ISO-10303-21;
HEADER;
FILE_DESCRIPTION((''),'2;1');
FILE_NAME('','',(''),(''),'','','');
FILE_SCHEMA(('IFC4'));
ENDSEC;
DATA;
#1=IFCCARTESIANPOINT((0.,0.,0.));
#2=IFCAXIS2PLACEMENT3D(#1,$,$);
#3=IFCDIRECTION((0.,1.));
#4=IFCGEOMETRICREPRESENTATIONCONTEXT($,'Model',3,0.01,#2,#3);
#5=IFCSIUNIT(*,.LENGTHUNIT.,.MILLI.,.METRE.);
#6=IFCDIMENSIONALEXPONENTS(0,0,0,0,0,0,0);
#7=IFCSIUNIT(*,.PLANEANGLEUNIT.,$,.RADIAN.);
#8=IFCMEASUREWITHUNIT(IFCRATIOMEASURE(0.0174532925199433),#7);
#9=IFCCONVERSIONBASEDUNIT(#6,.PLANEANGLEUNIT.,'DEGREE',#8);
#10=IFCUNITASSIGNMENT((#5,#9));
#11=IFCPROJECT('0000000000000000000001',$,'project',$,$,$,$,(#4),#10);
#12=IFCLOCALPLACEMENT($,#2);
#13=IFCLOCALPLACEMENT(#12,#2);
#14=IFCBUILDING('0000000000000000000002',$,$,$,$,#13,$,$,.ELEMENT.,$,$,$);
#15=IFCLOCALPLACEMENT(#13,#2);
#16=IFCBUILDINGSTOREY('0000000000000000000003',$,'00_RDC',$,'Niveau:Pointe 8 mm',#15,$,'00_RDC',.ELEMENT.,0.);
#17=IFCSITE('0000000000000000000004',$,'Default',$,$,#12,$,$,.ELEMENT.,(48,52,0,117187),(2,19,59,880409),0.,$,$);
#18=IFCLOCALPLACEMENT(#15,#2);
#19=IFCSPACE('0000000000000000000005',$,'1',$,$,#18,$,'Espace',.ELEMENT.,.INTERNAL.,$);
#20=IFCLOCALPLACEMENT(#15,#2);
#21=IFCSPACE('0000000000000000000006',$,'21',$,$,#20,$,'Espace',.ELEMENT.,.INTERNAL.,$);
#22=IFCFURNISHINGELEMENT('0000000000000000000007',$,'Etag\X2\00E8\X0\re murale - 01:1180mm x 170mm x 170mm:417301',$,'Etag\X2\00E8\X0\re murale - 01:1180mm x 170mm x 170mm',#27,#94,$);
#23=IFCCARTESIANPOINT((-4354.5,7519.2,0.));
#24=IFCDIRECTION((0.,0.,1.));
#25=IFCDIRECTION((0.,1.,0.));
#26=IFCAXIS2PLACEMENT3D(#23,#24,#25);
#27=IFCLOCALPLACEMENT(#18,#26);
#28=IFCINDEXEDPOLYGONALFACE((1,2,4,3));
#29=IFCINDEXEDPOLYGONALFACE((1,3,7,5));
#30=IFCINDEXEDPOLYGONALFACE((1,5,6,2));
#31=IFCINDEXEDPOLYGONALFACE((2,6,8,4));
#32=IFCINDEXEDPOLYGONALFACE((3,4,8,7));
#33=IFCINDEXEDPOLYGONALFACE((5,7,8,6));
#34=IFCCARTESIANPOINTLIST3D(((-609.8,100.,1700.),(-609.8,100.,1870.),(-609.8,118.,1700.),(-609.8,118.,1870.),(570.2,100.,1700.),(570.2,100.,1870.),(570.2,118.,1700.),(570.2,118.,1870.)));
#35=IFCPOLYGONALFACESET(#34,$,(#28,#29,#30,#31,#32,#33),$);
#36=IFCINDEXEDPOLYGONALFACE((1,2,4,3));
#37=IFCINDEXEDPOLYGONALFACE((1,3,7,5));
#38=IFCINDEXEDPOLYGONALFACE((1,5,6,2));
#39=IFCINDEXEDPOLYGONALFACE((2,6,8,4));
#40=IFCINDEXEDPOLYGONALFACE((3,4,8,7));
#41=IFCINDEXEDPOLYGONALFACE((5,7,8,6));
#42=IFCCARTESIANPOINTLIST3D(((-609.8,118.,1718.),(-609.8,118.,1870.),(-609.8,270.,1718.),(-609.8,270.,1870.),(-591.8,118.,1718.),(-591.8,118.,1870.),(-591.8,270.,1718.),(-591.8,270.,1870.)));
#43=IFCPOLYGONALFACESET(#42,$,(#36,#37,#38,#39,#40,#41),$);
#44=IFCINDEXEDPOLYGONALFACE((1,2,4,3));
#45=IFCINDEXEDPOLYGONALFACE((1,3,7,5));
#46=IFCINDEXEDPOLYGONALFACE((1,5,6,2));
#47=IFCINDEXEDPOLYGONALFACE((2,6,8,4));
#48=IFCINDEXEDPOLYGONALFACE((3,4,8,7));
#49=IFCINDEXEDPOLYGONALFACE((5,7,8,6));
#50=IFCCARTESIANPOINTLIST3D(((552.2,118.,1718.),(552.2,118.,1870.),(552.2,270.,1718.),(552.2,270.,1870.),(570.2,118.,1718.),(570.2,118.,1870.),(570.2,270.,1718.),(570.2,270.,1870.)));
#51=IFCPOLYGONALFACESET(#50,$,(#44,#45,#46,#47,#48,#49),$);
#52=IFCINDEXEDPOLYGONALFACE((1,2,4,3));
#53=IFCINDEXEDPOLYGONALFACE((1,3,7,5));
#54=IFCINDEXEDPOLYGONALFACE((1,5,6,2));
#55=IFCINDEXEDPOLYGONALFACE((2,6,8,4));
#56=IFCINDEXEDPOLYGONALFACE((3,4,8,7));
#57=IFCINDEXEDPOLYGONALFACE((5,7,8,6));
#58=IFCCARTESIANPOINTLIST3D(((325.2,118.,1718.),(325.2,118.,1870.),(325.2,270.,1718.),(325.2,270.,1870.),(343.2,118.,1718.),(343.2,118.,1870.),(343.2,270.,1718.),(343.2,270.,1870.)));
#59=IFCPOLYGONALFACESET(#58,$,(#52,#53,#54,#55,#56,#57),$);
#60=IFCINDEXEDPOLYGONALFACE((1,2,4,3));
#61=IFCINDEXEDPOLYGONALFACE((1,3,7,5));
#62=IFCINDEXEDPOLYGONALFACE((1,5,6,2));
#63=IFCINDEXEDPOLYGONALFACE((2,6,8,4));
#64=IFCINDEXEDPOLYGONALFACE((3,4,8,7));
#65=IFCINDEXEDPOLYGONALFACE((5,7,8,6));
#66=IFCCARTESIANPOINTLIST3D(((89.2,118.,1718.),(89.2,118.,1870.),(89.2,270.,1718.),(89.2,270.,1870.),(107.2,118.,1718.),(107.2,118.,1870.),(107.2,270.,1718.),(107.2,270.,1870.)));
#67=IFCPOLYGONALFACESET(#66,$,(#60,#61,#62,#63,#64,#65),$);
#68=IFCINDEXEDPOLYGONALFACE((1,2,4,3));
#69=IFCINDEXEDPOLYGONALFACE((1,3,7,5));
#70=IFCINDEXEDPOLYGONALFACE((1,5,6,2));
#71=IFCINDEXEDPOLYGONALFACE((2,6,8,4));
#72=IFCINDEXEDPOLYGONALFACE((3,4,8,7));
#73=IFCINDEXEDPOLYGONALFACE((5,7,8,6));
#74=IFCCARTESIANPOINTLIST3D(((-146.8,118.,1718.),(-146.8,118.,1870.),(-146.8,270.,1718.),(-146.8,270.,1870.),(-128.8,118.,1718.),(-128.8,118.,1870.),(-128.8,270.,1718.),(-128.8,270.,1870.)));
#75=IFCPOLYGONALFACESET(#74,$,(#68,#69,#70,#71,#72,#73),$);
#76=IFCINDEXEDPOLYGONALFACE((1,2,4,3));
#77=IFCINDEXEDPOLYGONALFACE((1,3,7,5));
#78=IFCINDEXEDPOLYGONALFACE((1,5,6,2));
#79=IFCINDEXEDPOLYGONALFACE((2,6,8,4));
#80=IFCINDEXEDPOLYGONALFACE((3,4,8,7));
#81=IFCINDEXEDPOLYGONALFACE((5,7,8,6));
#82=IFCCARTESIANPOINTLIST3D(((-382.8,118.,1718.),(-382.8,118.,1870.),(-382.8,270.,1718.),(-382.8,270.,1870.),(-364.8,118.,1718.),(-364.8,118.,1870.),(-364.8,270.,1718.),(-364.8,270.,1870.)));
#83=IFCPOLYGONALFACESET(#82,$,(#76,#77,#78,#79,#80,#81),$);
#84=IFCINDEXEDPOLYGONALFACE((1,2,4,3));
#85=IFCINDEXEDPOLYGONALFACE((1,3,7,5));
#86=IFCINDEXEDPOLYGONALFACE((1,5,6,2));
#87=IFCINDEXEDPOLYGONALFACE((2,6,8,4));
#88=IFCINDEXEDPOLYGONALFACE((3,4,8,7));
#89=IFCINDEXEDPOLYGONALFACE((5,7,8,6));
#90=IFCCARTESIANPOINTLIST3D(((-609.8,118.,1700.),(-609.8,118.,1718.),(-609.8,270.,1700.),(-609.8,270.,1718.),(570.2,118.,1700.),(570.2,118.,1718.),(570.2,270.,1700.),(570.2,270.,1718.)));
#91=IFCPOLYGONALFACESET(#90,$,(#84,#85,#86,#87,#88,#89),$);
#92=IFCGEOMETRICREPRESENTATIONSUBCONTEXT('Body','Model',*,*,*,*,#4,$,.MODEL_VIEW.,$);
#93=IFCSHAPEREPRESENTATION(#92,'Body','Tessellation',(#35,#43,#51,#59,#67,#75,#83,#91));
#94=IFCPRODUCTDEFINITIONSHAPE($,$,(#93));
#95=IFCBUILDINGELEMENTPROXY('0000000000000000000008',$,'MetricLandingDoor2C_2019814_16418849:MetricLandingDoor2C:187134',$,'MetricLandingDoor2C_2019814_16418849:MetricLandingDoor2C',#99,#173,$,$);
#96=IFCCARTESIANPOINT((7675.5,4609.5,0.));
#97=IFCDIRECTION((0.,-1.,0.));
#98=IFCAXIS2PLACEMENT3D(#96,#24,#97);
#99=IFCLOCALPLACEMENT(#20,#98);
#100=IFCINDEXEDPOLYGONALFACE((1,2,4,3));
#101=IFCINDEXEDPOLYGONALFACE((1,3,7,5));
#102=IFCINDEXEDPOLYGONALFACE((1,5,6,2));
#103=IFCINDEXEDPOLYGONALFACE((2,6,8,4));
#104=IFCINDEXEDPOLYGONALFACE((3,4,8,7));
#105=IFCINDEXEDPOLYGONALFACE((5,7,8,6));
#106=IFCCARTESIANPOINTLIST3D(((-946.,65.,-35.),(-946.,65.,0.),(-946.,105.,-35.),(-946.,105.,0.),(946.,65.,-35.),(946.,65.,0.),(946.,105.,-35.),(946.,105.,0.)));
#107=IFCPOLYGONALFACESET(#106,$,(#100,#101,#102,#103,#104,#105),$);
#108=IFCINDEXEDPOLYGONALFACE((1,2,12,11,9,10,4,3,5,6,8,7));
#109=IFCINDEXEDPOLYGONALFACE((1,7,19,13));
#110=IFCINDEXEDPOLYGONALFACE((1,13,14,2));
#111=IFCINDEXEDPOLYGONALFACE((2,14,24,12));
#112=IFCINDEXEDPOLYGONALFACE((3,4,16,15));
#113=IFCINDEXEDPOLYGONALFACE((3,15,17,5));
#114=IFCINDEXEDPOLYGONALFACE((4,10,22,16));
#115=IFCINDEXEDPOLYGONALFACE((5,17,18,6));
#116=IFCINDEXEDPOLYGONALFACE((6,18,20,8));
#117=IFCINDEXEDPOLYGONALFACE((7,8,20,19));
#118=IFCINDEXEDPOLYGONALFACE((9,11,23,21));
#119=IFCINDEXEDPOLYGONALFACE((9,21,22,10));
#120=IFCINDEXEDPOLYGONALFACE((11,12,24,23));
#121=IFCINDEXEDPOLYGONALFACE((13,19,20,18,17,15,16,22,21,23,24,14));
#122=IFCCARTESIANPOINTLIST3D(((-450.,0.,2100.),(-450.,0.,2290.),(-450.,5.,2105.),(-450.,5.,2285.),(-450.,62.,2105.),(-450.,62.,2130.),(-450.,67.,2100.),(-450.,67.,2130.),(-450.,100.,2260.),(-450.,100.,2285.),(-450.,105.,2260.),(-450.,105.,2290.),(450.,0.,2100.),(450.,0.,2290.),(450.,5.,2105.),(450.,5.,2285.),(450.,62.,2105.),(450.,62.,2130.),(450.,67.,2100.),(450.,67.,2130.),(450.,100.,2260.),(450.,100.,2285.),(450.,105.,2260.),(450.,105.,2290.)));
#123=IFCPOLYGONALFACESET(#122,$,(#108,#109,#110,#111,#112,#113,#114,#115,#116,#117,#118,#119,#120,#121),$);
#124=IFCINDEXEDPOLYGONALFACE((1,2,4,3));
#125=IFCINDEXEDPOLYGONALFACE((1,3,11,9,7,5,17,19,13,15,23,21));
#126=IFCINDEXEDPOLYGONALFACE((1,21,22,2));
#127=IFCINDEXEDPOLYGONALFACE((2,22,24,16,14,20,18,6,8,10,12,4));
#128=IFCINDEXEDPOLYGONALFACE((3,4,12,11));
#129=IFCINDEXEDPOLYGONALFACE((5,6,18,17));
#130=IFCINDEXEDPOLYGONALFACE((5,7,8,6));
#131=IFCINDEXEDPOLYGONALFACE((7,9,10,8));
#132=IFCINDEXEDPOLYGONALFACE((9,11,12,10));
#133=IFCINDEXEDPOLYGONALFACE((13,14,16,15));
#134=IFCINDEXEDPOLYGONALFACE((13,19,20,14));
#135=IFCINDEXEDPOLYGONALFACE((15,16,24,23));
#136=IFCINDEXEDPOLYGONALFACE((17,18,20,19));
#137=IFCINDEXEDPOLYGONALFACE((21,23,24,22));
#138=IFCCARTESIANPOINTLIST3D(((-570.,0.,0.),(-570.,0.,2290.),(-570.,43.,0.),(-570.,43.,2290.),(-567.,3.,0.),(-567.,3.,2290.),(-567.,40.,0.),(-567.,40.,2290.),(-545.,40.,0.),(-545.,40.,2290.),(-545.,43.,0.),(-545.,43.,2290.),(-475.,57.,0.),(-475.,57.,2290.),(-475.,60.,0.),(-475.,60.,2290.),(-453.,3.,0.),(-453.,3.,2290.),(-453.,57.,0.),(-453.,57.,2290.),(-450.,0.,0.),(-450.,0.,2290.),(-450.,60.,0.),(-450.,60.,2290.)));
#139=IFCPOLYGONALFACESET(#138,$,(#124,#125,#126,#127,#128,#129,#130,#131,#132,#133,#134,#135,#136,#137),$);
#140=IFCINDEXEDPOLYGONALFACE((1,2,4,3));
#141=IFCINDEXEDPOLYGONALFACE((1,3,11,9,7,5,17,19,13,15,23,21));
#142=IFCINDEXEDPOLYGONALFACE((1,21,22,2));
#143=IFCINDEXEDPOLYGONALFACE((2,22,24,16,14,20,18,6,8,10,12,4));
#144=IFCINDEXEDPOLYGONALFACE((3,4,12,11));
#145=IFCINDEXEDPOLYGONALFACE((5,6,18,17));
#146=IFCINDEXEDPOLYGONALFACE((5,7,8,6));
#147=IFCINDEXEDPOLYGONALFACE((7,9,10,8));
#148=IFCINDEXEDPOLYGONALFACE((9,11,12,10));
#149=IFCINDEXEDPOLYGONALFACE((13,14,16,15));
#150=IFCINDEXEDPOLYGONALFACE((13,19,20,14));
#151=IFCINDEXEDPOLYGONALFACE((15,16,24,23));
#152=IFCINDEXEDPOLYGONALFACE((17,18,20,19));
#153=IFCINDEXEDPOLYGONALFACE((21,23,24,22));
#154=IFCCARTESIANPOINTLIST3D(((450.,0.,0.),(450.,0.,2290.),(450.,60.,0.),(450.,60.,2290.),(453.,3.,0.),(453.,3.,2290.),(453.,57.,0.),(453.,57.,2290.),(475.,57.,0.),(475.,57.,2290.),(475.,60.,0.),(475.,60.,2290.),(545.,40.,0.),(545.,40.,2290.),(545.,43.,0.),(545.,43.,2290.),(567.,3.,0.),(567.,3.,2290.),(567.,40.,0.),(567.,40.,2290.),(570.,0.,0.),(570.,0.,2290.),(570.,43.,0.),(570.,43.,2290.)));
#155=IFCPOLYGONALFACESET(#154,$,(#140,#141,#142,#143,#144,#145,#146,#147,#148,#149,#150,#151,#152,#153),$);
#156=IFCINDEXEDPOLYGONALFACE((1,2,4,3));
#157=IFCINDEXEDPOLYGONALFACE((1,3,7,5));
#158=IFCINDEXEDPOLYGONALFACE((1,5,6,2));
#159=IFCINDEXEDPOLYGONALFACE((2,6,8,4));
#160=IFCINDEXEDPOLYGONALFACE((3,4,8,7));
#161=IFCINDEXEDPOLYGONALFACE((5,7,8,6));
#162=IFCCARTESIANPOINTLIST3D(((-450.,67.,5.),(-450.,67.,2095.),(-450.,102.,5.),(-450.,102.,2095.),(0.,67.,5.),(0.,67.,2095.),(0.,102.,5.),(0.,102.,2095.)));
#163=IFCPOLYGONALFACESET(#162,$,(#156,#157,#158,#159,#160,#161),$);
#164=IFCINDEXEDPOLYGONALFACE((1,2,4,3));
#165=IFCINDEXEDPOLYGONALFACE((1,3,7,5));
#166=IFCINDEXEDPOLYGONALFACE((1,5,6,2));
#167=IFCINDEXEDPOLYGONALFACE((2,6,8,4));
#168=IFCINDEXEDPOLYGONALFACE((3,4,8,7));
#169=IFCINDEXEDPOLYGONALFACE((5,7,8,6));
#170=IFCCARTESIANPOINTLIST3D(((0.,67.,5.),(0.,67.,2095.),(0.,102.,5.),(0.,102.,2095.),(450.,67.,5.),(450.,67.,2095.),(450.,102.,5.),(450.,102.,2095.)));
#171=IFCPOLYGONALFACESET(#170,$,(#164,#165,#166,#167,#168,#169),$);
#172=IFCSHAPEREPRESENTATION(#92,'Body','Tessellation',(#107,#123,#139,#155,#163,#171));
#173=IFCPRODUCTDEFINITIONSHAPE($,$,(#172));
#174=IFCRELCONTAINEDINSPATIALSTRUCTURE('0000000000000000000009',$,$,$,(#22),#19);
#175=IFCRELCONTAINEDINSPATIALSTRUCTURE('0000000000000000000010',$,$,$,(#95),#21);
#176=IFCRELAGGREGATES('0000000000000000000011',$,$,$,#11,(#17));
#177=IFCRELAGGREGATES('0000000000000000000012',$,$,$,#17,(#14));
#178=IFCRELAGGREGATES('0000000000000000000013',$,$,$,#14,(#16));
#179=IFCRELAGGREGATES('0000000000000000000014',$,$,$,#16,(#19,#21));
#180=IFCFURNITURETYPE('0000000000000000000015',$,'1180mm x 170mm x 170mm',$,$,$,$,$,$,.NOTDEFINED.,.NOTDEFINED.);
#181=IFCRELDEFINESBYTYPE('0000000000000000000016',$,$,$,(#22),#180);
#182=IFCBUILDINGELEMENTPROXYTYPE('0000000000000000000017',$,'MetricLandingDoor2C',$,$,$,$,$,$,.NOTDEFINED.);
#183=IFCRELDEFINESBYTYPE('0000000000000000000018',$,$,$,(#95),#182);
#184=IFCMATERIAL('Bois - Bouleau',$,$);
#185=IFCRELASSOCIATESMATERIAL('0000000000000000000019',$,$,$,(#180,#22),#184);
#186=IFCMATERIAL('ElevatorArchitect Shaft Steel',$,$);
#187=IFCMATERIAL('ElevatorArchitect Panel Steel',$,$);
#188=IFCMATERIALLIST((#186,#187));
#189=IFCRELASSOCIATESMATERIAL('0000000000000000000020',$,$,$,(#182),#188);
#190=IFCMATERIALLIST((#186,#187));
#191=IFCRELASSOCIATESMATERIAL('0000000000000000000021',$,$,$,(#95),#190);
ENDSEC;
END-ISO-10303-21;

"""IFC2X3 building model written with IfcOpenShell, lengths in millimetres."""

from ifc_helpers import new_model, entity, si_unit, converted_unit, direction, frame, frame_2d, origin, origin_2d_with_axis, place, context, subcontext, project, spatial, polyline, rectangle, outline, extrude, source, transform, mapped, material, material_list, type_object, type_shapes, element, save


model = new_model("IFC2X3")

# Units and contexts
model_context = context("Model", 3, precision=0.01, world=origin(), true_north=direction((0.0, 1.0)))
body_context = subcontext(model_context, "Body", "Model", "MODEL_VIEW")
ifc_project = project(units=[si_unit("LENGTHUNIT", "METRE", prefix="MILLI"), converted_unit("PLANEANGLEUNIT", "DEGREE", entity("IfcRatioMeasure", 0.0174532925199433), si_unit("PLANEANGLEUNIT", "RADIAN"), dimensions=[0, 0, 0, 0, 0, 0, 0])], contexts=[model_context])

# Site, building, storey
site_placement = place(None, origin())
site = spatial("IfcSite", under=ifc_project, at=site_placement, Name="Default", CompositionType="ELEMENT", RefLatitude=(48, 52, 0, 117187), RefLongitude=(2, 19, 59, 880409), RefElevation=0.0)
building_placement = place(site_placement, origin())
building = spatial("IfcBuilding", under=site, at=building_placement, CompositionType="ELEMENT")
storey_placement = place(building_placement, origin())
storey = spatial("IfcBuildingStorey", under=building, at=storey_placement, Name="00_RDC", ObjectType="Niveau:Pointe 8 mm", LongName="00_RDC", CompositionType="ELEMENT", Elevation=0.0)

# Shared definitions
space_1_placement = place(storey_placement, origin())
space_1 = spatial("IfcSpace", under=storey, at=space_1_placement, Name="1", LongName="Espace", CompositionType="ELEMENT", InteriorOrExteriorSpace="INTERNAL")

# Furnishing element
ifc_material_1 = material(Name="Bois - Bouleau")
furniture_type = type_object("IfcFurnitureType", Name="1180mm x 170mm x 170mm", material=ifc_material_1)
shared_shape_1 = source(origin(), body_context, "Body", "SweptSolid", [
    extrude(rectangle(XDim=18.0, YDim=1180.0, at=origin_2d_with_axis()), frame((-19.8, 109.0, 1700.0), z_axis=(0.0, 0.0, 1.0), x_axis=(0.0, 1.0, 0.0)), (0.0, 0.0, 1.0), 170.0),
    extrude(rectangle(XDim=152.0, YDim=18.0, at=origin_2d_with_axis()), frame((-600.8, 194.0, 1718.0), z_axis=(0.0, 0.0, 1.0), x_axis=(0.0, 1.0, 0.0)), (0.0, 0.0, 1.0), 152.0),
    extrude(rectangle(XDim=152.0, YDim=18.0, at=origin_2d_with_axis()), frame((561.2, 194.0, 1718.0), z_axis=(0.0, 0.0, 1.0), x_axis=(0.0, 1.0, 0.0)), (0.0, 0.0, 1.0), 152.0),
    extrude(rectangle(XDim=152.0, YDim=18.0, at=origin_2d_with_axis()), frame((334.2, 194.0, 1718.0), z_axis=(0.0, 0.0, 1.0), x_axis=(0.0, 1.0, 0.0)), (0.0, 0.0, 1.0), 152.0),
    extrude(rectangle(XDim=152.0, YDim=18.0, at=origin_2d_with_axis()), frame((98.2, 194.0, 1718.0), z_axis=(0.0, 0.0, 1.0), x_axis=(0.0, 1.0, 0.0)), (0.0, 0.0, 1.0), 152.0),
    extrude(rectangle(XDim=152.0, YDim=18.0, at=origin_2d_with_axis()), frame((-137.8, 194.0, 1718.0), z_axis=(0.0, 0.0, 1.0), x_axis=(0.0, 1.0, 0.0)), (0.0, 0.0, 1.0), 152.0),
    extrude(rectangle(XDim=152.0, YDim=18.0, at=origin_2d_with_axis()), frame((-373.8, 194.0, 1718.0), z_axis=(0.0, 0.0, 1.0), x_axis=(0.0, 1.0, 0.0)), (0.0, 0.0, 1.0), 152.0),
    extrude(rectangle(XDim=152.0, YDim=1180.0, at=origin_2d_with_axis()), frame((-19.8, 194.0, 1700.0), z_axis=(0.0, 0.0, 1.0), x_axis=(0.0, 1.0, 0.0)), (0.0, 0.0, 1.0), 18.0),
])
type_shapes(furniture_type, [shared_shape_1])
furnishing_placement = place(space_1_placement, frame((-4354.5, 7519.2, 0.0), z_axis=(0.0, 0.0, 1.0), x_axis=(0.0, 1.0, 0.0)))
element("IfcFurnishingElement", 1, at=furnishing_placement, inside=space_1, type_object=furniture_type, material=ifc_material_1, Name="Etagère murale - 01:1180mm x 170mm x 170mm:417301", ObjectType="Etagère murale - 01:1180mm x 170mm x 170mm", context=body_context, shape_type="MappedRepresentation", body=[
    mapped(shared_shape_1, transform((0.0, 0.0, 0.0), scale=1.0)),
])

# Shared definitions
space_2_placement = place(storey_placement, origin())
space_2 = spatial("IfcSpace", under=storey, at=space_2_placement, Name="21", LongName="Espace", CompositionType="ELEMENT", InteriorOrExteriorSpace="INTERNAL")

# Shared definitions
ifc_material_2 = material(Name="ElevatorArchitect Panel Steel")
ifc_material_3 = material(Name="ElevatorArchitect Shaft Steel")

# Building element proxy
ifc_material_list_1 = material_list([ifc_material_3, ifc_material_2])
ifc_material_list_2 = material_list([ifc_material_3, ifc_material_2])
building_element_proxy_type_1 = type_object("IfcBuildingElementProxyType", Name="MetricLandingDoor2C", PredefinedType="NOTDEFINED", material=ifc_material_list_2)
shared_shape_2 = source(origin(), body_context, "Body", "SweptSolid", [
    extrude(rectangle(XDim=1892.0, YDim=40.0, at=origin_2d_with_axis()), frame((0.0, 85.0, -35.0), z_axis=(0.0, 0.0, 1.0), x_axis=(-1.0, 0.0, 0.0)), (0.0, 0.0, 1.0), 35.0),
    extrude(outline(polyline([(-48.5, -95.0), (56.5, -95.0), (56.5, 95.0), (-10.5, 95.0), (-10.5, 65.0), (-5.5, 65.0), (-5.5, 90.0), (51.5, 90.0), (51.5, -90.0), (-43.5, -90.0), (-43.5, -65.0), (-48.5, -65.0), (-48.5, -95.0)])), frame((-450.0, 56.5, 2195.0), z_axis=(1.0, 0.0, 0.0), x_axis=(0.0, -1.0, 0.0)), (0.0, 0.0, 1.0), 900.0),
    extrude(outline(polyline([(-33.8, -60.0), (26.2, -60.0), (26.2, -35.0), (23.2, -35.0), (23.2, -57.0), (-30.8, -57.0), (-30.8, 57.0), (6.2, 57.0), (6.2, 35.0), (9.2, 35.0), (9.2, 60.0), (-33.8, 60.0), (-33.8, -60.0)])), frame((-510.0, 33.8, 0.0), z_axis=(0.0, 0.0, 1.0), x_axis=(0.0, 1.0, 0.0)), (0.0, 0.0, 1.0), 2290.0),
    extrude(outline(polyline([(-60.0, -33.8), (60.0, -33.8), (60.0, 9.2), (35.0, 9.2), (35.0, 6.2), (57.0, 6.2), (57.0, -30.8), (-57.0, -30.8), (-57.0, 23.2), (-35.0, 23.2), (-35.0, 26.2), (-60.0, 26.2), (-60.0, -33.8)])), frame((510.0, 33.8, 0.0)), (0.0, 0.0, 1.0), 2290.0),
    extrude(rectangle(XDim=35.0, YDim=450.0, at=frame_2d((0.0, 0.0), x_axis=(1.0, 0.0))), frame((-225.0, 84.5, 5.0), z_axis=(0.0, 0.0, 1.0), x_axis=(0.0, -1.0, 0.0)), (0.0, 0.0, 1.0), 2090.0),
    extrude(rectangle(XDim=35.0, YDim=450.0, at=origin_2d_with_axis()), frame((225.0, 84.5, 5.0), z_axis=(0.0, 0.0, 1.0), x_axis=(0.0, -1.0, 0.0)), (0.0, 0.0, 1.0), 2090.0),
])
type_shapes(building_element_proxy_type_1, [shared_shape_2])
proxy_1_placement = place(space_2_placement, frame((7675.5, 4609.5, 0.0), z_axis=(0.0, 0.0, 1.0), x_axis=(0.0, -1.0, 0.0)))
element("IfcBuildingElementProxy", 2, at=proxy_1_placement, inside=space_2, type_object=building_element_proxy_type_1, material=ifc_material_list_1, Name="MetricLandingDoor2C_2019814_16418849:MetricLandingDoor2C:187134", ObjectType="MetricLandingDoor2C_2019814_16418849:MetricLandingDoor2C", context=body_context, shape_type="MappedRepresentation", body=[
    mapped(shared_shape_2, transform((0.0, 0.0, 0.0), scale=1.0)),
])

save(model, "model.ifc")
